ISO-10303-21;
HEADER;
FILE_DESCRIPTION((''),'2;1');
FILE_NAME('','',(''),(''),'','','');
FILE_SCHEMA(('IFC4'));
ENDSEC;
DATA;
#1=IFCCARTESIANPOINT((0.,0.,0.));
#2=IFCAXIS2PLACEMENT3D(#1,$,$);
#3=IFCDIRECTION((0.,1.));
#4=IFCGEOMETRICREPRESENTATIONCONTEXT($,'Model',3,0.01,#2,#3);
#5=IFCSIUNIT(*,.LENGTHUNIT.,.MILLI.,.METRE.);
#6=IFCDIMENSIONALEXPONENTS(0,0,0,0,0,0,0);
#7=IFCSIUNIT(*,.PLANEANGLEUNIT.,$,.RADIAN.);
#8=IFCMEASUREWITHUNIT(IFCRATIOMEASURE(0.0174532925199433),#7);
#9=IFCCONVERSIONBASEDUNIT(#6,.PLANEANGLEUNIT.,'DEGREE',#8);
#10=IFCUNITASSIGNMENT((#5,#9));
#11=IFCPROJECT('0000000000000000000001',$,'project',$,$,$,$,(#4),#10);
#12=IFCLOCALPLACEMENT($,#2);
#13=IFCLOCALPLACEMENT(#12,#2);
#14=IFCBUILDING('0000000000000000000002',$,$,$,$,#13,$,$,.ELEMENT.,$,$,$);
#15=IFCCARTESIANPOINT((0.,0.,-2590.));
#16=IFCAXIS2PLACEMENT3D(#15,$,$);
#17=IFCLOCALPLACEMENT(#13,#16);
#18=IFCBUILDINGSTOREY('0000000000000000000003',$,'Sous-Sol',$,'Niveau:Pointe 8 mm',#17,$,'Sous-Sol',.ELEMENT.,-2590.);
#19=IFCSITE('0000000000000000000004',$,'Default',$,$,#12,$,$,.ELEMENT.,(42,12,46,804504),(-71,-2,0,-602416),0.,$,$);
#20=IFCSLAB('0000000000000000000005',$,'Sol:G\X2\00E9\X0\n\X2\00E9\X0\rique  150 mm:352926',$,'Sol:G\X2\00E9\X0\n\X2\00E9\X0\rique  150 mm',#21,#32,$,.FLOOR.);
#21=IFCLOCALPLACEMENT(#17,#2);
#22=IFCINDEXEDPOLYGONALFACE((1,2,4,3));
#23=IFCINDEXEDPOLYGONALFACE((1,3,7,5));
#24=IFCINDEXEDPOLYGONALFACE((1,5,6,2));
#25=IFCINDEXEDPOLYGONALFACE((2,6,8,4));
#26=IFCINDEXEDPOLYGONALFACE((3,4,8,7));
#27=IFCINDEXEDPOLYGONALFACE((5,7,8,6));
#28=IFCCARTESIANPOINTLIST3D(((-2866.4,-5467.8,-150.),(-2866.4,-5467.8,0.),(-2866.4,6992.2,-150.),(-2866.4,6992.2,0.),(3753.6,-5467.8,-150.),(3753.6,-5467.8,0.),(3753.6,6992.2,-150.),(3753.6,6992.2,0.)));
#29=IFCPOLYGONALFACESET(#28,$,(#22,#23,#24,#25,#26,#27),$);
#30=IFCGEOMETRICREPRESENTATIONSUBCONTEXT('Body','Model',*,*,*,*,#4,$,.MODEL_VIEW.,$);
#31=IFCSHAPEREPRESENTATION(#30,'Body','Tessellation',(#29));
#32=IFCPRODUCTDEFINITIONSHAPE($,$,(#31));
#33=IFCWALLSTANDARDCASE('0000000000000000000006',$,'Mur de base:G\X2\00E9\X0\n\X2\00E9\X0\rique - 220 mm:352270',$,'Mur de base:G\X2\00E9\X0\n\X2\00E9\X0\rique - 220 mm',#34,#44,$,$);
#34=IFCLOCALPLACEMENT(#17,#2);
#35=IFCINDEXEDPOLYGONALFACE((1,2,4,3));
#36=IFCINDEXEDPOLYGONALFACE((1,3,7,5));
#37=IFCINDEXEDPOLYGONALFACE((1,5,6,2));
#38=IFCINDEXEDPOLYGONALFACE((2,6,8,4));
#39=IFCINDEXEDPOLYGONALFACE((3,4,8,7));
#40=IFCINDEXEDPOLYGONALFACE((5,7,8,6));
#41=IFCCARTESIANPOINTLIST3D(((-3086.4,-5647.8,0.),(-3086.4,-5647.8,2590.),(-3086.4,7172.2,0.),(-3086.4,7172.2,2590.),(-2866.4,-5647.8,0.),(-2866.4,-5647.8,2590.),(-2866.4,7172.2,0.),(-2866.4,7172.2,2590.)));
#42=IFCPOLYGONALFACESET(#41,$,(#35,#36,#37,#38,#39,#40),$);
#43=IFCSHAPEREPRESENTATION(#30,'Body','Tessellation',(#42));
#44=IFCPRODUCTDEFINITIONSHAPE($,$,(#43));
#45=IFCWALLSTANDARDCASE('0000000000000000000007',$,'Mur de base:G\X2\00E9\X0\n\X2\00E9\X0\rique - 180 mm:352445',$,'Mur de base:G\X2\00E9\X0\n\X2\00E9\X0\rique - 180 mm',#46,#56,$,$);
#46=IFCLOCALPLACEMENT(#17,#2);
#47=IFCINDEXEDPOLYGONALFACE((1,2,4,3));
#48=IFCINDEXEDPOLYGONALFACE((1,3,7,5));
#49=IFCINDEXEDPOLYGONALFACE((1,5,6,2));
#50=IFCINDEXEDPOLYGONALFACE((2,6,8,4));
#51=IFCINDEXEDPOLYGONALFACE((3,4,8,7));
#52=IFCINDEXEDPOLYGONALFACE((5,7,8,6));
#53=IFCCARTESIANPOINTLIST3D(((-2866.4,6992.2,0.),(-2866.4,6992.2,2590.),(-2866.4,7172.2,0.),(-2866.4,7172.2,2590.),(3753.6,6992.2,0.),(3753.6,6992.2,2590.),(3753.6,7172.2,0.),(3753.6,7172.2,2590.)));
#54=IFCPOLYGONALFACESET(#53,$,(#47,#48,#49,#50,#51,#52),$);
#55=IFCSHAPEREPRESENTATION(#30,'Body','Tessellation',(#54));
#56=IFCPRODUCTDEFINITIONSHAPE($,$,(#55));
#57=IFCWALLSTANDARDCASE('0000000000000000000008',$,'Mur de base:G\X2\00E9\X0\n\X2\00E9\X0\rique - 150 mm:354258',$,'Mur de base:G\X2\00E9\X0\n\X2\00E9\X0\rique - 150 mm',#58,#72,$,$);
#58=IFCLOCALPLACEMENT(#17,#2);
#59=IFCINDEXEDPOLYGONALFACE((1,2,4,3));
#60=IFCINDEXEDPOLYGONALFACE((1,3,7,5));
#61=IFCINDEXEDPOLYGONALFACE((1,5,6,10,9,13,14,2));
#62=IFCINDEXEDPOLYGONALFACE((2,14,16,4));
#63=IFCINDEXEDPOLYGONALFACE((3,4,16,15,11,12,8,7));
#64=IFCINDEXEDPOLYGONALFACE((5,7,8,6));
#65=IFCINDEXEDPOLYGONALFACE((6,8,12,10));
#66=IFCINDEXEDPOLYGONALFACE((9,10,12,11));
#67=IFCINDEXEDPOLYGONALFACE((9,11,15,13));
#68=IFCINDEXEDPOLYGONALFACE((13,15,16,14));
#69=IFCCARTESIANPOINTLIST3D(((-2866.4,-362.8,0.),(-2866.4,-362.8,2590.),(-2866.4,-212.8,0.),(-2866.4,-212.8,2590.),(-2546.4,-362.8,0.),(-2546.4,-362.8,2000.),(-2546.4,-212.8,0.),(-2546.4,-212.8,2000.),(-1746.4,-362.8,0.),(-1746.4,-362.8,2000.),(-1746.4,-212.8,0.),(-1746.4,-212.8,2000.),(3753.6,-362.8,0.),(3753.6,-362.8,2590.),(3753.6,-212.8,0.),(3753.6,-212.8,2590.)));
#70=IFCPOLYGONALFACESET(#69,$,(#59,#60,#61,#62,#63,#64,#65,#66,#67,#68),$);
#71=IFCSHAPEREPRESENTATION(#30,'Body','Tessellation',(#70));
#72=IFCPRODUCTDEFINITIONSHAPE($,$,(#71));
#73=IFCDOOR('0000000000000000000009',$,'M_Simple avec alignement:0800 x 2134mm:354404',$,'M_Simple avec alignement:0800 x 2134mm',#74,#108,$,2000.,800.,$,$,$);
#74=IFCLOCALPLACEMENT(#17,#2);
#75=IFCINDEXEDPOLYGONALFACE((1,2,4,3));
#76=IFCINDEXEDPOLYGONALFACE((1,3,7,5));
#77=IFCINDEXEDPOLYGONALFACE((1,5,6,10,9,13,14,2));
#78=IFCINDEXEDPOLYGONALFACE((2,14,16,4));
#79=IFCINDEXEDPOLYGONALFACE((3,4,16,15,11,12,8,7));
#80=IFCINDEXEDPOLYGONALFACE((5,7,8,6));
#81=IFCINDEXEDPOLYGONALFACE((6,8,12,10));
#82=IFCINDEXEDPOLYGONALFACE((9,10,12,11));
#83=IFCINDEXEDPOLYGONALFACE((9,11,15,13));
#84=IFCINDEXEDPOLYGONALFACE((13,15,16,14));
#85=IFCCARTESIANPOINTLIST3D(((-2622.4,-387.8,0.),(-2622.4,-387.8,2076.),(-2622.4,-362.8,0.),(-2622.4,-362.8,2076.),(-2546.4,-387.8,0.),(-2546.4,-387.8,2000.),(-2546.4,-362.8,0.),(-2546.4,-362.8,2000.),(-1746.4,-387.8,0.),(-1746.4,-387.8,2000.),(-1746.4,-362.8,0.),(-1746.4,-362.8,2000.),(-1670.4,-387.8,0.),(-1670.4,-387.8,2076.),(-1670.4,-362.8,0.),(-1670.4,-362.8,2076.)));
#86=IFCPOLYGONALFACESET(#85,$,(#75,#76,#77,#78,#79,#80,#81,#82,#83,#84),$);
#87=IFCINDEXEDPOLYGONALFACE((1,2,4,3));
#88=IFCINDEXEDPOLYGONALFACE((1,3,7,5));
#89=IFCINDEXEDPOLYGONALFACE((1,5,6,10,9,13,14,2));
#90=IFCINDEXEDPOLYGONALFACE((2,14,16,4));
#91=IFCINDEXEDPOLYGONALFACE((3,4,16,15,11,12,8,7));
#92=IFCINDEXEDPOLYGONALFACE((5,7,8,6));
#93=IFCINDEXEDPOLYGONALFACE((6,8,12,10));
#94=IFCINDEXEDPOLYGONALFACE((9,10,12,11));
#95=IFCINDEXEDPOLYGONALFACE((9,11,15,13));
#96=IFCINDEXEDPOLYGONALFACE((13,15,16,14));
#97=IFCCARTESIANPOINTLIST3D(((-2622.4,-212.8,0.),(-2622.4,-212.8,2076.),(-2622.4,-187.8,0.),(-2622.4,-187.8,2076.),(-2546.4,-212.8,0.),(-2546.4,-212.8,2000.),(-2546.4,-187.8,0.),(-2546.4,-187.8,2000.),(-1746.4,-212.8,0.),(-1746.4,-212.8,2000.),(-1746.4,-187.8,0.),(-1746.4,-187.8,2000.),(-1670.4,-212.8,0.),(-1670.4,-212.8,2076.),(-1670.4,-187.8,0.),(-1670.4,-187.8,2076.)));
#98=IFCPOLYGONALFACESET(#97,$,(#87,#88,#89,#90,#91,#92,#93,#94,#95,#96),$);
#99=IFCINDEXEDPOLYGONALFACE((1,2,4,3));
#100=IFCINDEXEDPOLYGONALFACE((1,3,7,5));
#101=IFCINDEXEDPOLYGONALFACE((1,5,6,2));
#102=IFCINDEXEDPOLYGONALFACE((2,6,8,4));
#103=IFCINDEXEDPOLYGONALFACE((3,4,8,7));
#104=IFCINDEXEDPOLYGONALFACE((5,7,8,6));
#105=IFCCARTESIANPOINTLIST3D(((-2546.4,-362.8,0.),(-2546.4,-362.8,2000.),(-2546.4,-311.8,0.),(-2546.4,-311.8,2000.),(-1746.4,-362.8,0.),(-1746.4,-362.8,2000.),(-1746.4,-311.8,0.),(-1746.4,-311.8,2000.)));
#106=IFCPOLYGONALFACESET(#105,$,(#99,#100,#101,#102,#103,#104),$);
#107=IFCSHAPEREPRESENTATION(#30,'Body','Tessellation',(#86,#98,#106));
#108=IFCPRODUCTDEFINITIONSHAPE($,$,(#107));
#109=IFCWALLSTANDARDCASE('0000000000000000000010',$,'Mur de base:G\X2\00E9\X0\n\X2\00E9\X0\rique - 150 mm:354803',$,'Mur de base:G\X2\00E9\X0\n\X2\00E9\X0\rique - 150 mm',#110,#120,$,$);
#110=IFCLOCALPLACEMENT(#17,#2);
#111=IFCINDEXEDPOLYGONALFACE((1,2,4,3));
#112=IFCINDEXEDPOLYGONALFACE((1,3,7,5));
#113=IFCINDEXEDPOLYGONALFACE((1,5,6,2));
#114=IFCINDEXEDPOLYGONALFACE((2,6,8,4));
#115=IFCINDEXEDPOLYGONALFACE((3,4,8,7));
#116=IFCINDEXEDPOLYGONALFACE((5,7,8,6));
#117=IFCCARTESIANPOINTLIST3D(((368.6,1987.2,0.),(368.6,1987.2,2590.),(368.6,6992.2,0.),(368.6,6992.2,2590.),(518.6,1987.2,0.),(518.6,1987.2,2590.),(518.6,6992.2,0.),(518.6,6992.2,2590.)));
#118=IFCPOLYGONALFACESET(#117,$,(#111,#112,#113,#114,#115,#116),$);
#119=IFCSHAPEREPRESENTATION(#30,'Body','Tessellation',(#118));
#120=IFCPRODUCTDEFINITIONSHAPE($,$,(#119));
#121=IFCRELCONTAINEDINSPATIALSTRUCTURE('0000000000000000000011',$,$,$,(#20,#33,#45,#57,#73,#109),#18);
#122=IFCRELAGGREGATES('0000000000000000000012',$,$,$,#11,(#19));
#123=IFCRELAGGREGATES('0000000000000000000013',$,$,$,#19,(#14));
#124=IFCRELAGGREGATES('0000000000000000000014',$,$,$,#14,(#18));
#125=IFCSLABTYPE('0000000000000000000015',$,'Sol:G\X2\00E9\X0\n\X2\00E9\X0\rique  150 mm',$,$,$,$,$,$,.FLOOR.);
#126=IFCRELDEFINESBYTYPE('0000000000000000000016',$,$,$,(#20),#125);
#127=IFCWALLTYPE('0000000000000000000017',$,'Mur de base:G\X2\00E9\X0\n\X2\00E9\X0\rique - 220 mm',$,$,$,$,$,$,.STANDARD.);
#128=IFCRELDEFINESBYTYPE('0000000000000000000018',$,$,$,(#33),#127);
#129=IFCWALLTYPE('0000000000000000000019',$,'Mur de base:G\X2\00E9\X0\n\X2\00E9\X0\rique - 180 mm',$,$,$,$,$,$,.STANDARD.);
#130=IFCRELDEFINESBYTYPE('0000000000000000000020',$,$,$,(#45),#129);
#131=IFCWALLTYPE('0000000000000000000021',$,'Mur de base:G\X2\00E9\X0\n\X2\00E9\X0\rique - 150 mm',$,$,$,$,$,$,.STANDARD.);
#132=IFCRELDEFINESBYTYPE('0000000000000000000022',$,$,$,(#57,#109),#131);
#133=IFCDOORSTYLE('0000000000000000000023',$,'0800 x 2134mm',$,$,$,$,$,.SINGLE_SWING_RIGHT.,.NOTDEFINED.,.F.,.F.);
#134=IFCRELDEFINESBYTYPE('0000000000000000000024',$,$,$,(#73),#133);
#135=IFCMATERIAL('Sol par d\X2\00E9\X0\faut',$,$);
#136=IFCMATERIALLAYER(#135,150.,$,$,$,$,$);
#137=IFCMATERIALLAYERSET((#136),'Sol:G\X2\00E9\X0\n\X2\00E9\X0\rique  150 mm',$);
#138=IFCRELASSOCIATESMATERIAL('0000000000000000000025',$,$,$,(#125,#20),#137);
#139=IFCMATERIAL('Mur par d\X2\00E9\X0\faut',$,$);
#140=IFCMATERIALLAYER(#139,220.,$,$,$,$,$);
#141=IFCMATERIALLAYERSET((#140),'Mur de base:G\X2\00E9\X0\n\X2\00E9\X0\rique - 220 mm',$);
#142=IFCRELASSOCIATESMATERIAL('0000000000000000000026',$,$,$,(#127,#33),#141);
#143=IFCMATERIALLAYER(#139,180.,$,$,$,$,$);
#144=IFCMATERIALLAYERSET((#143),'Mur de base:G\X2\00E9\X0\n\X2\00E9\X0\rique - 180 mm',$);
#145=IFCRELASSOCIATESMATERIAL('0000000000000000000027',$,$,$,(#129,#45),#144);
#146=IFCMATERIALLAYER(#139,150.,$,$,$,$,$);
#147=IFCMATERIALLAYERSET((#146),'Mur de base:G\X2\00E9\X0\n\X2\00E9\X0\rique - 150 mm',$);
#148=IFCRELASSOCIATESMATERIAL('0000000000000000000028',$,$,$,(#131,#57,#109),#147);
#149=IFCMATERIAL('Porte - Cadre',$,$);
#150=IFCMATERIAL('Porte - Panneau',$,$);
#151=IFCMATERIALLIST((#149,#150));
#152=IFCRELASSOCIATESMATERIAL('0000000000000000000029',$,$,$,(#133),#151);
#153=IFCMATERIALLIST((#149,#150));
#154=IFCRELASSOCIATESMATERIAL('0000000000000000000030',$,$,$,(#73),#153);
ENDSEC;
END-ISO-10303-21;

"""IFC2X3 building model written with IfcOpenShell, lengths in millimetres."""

from ifc_helpers import new_model, entity, si_unit, converted_unit, direction, frame, frame_2d, origin, place, context, subcontext, project, spatial, polyline, rectangle, outline, extrude, source, transform, mapped, material, material_list, layer, layer_set, layer_usage, type_object, type_shapes, element, fill, save


model = new_model("IFC2X3")

# Units and contexts
model_context = context("Model", 3, precision=0.01, world=origin(), true_north=direction((0.0, 1.0)))
body_context = subcontext(model_context, "Body", "Model", "MODEL_VIEW")
ifc_project = project(units=[si_unit("LENGTHUNIT", "METRE", prefix="MILLI"), converted_unit("PLANEANGLEUNIT", "DEGREE", entity("IfcRatioMeasure", 0.0174532925199433), si_unit("PLANEANGLEUNIT", "RADIAN"), dimensions=[0, 0, 0, 0, 0, 0, 0])], contexts=[model_context])

# Site, building, storey
site_placement = place(None, origin())
site = spatial("IfcSite", under=ifc_project, at=site_placement, Name="Default", CompositionType="ELEMENT", RefLatitude=(42, 12, 46, 804504), RefLongitude=(-71, -2, 0, -602416), RefElevation=0.0)
building_placement = place(site_placement, origin())
building = spatial("IfcBuilding", under=site, at=building_placement, CompositionType="ELEMENT")
storey_placement = place(building_placement, frame((0.0, 0.0, -2590.0)))
storey = spatial("IfcBuildingStorey", under=building, at=storey_placement, Name="Sous-Sol", ObjectType="Niveau:Pointe 8 mm", LongName="Sous-Sol", CompositionType="ELEMENT", Elevation=-2590.0)

# Slab
ifc_material_1 = material(Name="Sol par défaut")
ifc_layer_1 = layer(ifc_material_1, 150.0)
ifc_layer_set_1 = layer_set([ifc_layer_1], Name="Sol:Générique  150 mm")
ifc_layer_usage_1 = layer_usage(ifc_layer_set_1, "AXIS3", "POSITIVE", 0.0)
slab_type = type_object("IfcSlabType", Name="Sol:Générique  150 mm", PredefinedType="FLOOR", material=ifc_layer_set_1)
slab_placement = place(storey_placement, origin())
element("IfcSlab", 1, at=slab_placement, inside=storey, type_object=slab_type, material=ifc_layer_usage_1, Name="Sol:Générique  150 mm:352926", ObjectType="Sol:Générique  150 mm", PredefinedType="FLOOR", context=body_context, shape_type="SweptSolid", body=[
    extrude(rectangle(XDim=12460.0, YDim=6620.0, at=frame_2d((0.0, 0.0), x_axis=(1.0, 0.0))), frame((443.6, 762.2, 0.0), z_axis=(0.0, 0.0, -1.0), x_axis=(0.0, 1.0, 0.0)), (0.0, 0.0, 1.0), 150.0),
])

# Walls
ifc_material_2 = material(Name="Mur par défaut")
ifc_layer_2 = layer(ifc_material_2, 220.0)
ifc_layer_set_2 = layer_set([ifc_layer_2], Name="Mur de base:Générique - 220 mm")
ifc_layer_usage_2 = layer_usage(ifc_layer_set_2, "AXIS2", "NEGATIVE", 110.0)
wall_type_1 = type_object("IfcWallType", Name="Mur de base:Générique - 220 mm", PredefinedType="STANDARD", material=ifc_layer_set_2)
wall_1_placement = place(storey_placement, frame((-2976.4, 7172.2, 0.0), z_axis=(0.0, 0.0, 1.0), x_axis=(0.0, -1.0, 0.0)))
element("IfcWallStandardCase", 2, at=wall_1_placement, inside=storey, type_object=wall_type_1, material=ifc_layer_usage_2, Name="Mur de base:Générique - 220 mm:352270", ObjectType="Mur de base:Générique - 220 mm", context=body_context, shape_type="SweptSolid", body=[
    extrude(rectangle(XDim=12820.0, YDim=220.0, at=frame_2d((6410.0, 0.0), x_axis=(-1.0, 0.0))), origin(), (0.0, 0.0, 1.0), 2590.0),
])
ifc_layer_3 = layer(ifc_material_2, 180.0)
ifc_layer_set_3 = layer_set([ifc_layer_3], Name="Mur de base:Générique - 180 mm")
ifc_layer_usage_3 = layer_usage(ifc_layer_set_3, "AXIS2", "NEGATIVE", 90.0)
wall_type_2 = type_object("IfcWallType", Name="Mur de base:Générique - 180 mm", PredefinedType="STANDARD", material=ifc_layer_set_3)
wall_2_placement = place(storey_placement, frame((3753.6, 7082.2, 0.0), z_axis=(0.0, 0.0, 1.0), x_axis=(-1.0, 0.0, 0.0)))
element("IfcWallStandardCase", 3, at=wall_2_placement, inside=storey, type_object=wall_type_2, material=ifc_layer_usage_3, Name="Mur de base:Générique - 180 mm:352445", ObjectType="Mur de base:Générique - 180 mm", context=body_context, shape_type="SweptSolid", body=[
    extrude(rectangle(XDim=6620.0, YDim=180.0, at=frame_2d((3310.0, 0.0), x_axis=(-1.0, 0.0))), origin(), (0.0, 0.0, 1.0), 2590.0),
])

# Wall, opening, door
ifc_layer_4 = layer(ifc_material_2, 150.0)
ifc_layer_set_4 = layer_set([ifc_layer_4], Name="Mur de base:Générique - 150 mm")
ifc_layer_usage_4 = layer_usage(ifc_layer_set_4, "AXIS2", "NEGATIVE", 75.0)
wall_type_3 = type_object("IfcWallType", Name="Mur de base:Générique - 150 mm", PredefinedType="STANDARD", material=ifc_layer_set_4)
wall_3_placement = place(storey_placement, frame((-2866.4, -287.8, 0.0)))
wall_3 = element("IfcWallStandardCase", 4, at=wall_3_placement, inside=storey, type_object=wall_type_3, material=ifc_layer_usage_4, Name="Mur de base:Générique - 150 mm:354258", ObjectType="Mur de base:Générique - 150 mm", context=body_context, shape_type="SweptSolid", body=[
    extrude(rectangle(XDim=6620.0, YDim=150.0, at=frame_2d((3310.0, 0.0), x_axis=(-1.0, 0.0))), origin(), (0.0, 0.0, 1.0), 2590.0),
])
opening_1_placement = place(wall_3_placement, frame((1120.0, 75.0, 0.0)))
opening_1 = element("IfcOpeningElement", 5, at=opening_1_placement, cuts=wall_3, ObjectType="Opening", context=body_context, shape_type="SweptSolid", body=[
    extrude(rectangle(XDim=800.0, YDim=2000.0, at=frame_2d((1000.0, 400.0), x_axis=(0.0, 1.0))), frame((0.0, 0.0, 0.0), z_axis=(0.0, -1.0, 0.0), x_axis=(0.0, 0.0, 1.0)), (0.0, 0.0, 1.0), 150.0),
])
ifc_material_3 = material(Name="Porte - Cadre")
ifc_material_4 = material(Name="Porte - Panneau")
ifc_material_list_1 = material_list([ifc_material_3, ifc_material_4])
ifc_material_list_2 = material_list([ifc_material_3, ifc_material_4])
door_style = type_object("IfcDoorStyle", Name="0800 x 2134mm", ConstructionType="NOTDEFINED", OperationType="SINGLE_SWING_RIGHT", ParameterTakesPrecedence=False, Sizeable=False, material=ifc_material_list_2)
shared_shape_1 = source(origin(), body_context, "Body", "SweptSolid", [
    extrude(outline(polyline([(-476.0, -1057.0), (476.0, -1057.0), (476.0, 1019.0), (400.0, 1019.0), (400.0, -981.0), (-400.0, -981.0), (-400.0, 1019.0), (-476.0, 1019.0), (-476.0, -1057.0)])), frame((400.0, 150.0, 1019.0), z_axis=(0.0, 1.0, 0.0), x_axis=(1.0, 0.0, 0.0)), (0.0, 0.0, 1.0), 25.0),
    extrude(outline(polyline([(-1057.0, -476.0), (1019.0, -476.0), (1019.0, -400.0), (-981.0, -400.0), (-981.0, 400.0), (1019.0, 400.0), (1019.0, 476.0), (-1057.0, 476.0), (-1057.0, -476.0)])), frame((400.0, -25.0, 1019.0), z_axis=(0.0, 1.0, 0.0), x_axis=(0.0, 0.0, -1.0)), (0.0, 0.0, 1.0), 25.0),
    extrude(rectangle(XDim=51.0, YDim=800.0, at=frame_2d((0.0, 0.0), x_axis=(1.0, 0.0))), frame((400.0, 124.5, 0.0), z_axis=(0.0, 0.0, 1.0), x_axis=(0.0, 1.0, 0.0)), (0.0, 0.0, 1.0), 2000.0),
])
type_shapes(door_style, [shared_shape_1])
door_1_placement = place(opening_1_placement, frame((0.0, 0.0, 0.0), z_axis=(0.0, 0.0, 1.0), x_axis=(-1.0, 0.0, 0.0)))
door_1 = element("IfcDoor", 6, at=door_1_placement, inside=storey, type_object=door_style, material=ifc_material_list_1, Name="M_Simple avec alignement:0800 x 2134mm:354404", ObjectType="M_Simple avec alignement:0800 x 2134mm", OverallHeight=2000.0, OverallWidth=800.0, context=body_context, shape_type="MappedRepresentation", body=[
    mapped(shared_shape_1, transform((0.0, 0.0, 0.0), scale=1.0)),
])
fill(opening_1, door_1)

# Wall
ifc_layer_usage_5 = layer_usage(ifc_layer_set_4, "AXIS2", "NEGATIVE", 75.0)
wall_4_placement = place(storey_placement, frame((443.6, 6992.2, 0.0), z_axis=(0.0, 0.0, 1.0), x_axis=(0.0, -1.0, 0.0)))
element("IfcWallStandardCase", 7, at=wall_4_placement, inside=storey, type_object=wall_type_3, material=ifc_layer_usage_5, Name="Mur de base:Générique - 150 mm:354803", ObjectType="Mur de base:Générique - 150 mm", context=body_context, shape_type="SweptSolid", body=[
    extrude(rectangle(XDim=5005.0, YDim=150.0, at=frame_2d((2502.5, 0.0), x_axis=(-1.0, 0.0))), origin(), (0.0, 0.0, 1.0), 2590.0),
])

save(model, "model.ifc")
